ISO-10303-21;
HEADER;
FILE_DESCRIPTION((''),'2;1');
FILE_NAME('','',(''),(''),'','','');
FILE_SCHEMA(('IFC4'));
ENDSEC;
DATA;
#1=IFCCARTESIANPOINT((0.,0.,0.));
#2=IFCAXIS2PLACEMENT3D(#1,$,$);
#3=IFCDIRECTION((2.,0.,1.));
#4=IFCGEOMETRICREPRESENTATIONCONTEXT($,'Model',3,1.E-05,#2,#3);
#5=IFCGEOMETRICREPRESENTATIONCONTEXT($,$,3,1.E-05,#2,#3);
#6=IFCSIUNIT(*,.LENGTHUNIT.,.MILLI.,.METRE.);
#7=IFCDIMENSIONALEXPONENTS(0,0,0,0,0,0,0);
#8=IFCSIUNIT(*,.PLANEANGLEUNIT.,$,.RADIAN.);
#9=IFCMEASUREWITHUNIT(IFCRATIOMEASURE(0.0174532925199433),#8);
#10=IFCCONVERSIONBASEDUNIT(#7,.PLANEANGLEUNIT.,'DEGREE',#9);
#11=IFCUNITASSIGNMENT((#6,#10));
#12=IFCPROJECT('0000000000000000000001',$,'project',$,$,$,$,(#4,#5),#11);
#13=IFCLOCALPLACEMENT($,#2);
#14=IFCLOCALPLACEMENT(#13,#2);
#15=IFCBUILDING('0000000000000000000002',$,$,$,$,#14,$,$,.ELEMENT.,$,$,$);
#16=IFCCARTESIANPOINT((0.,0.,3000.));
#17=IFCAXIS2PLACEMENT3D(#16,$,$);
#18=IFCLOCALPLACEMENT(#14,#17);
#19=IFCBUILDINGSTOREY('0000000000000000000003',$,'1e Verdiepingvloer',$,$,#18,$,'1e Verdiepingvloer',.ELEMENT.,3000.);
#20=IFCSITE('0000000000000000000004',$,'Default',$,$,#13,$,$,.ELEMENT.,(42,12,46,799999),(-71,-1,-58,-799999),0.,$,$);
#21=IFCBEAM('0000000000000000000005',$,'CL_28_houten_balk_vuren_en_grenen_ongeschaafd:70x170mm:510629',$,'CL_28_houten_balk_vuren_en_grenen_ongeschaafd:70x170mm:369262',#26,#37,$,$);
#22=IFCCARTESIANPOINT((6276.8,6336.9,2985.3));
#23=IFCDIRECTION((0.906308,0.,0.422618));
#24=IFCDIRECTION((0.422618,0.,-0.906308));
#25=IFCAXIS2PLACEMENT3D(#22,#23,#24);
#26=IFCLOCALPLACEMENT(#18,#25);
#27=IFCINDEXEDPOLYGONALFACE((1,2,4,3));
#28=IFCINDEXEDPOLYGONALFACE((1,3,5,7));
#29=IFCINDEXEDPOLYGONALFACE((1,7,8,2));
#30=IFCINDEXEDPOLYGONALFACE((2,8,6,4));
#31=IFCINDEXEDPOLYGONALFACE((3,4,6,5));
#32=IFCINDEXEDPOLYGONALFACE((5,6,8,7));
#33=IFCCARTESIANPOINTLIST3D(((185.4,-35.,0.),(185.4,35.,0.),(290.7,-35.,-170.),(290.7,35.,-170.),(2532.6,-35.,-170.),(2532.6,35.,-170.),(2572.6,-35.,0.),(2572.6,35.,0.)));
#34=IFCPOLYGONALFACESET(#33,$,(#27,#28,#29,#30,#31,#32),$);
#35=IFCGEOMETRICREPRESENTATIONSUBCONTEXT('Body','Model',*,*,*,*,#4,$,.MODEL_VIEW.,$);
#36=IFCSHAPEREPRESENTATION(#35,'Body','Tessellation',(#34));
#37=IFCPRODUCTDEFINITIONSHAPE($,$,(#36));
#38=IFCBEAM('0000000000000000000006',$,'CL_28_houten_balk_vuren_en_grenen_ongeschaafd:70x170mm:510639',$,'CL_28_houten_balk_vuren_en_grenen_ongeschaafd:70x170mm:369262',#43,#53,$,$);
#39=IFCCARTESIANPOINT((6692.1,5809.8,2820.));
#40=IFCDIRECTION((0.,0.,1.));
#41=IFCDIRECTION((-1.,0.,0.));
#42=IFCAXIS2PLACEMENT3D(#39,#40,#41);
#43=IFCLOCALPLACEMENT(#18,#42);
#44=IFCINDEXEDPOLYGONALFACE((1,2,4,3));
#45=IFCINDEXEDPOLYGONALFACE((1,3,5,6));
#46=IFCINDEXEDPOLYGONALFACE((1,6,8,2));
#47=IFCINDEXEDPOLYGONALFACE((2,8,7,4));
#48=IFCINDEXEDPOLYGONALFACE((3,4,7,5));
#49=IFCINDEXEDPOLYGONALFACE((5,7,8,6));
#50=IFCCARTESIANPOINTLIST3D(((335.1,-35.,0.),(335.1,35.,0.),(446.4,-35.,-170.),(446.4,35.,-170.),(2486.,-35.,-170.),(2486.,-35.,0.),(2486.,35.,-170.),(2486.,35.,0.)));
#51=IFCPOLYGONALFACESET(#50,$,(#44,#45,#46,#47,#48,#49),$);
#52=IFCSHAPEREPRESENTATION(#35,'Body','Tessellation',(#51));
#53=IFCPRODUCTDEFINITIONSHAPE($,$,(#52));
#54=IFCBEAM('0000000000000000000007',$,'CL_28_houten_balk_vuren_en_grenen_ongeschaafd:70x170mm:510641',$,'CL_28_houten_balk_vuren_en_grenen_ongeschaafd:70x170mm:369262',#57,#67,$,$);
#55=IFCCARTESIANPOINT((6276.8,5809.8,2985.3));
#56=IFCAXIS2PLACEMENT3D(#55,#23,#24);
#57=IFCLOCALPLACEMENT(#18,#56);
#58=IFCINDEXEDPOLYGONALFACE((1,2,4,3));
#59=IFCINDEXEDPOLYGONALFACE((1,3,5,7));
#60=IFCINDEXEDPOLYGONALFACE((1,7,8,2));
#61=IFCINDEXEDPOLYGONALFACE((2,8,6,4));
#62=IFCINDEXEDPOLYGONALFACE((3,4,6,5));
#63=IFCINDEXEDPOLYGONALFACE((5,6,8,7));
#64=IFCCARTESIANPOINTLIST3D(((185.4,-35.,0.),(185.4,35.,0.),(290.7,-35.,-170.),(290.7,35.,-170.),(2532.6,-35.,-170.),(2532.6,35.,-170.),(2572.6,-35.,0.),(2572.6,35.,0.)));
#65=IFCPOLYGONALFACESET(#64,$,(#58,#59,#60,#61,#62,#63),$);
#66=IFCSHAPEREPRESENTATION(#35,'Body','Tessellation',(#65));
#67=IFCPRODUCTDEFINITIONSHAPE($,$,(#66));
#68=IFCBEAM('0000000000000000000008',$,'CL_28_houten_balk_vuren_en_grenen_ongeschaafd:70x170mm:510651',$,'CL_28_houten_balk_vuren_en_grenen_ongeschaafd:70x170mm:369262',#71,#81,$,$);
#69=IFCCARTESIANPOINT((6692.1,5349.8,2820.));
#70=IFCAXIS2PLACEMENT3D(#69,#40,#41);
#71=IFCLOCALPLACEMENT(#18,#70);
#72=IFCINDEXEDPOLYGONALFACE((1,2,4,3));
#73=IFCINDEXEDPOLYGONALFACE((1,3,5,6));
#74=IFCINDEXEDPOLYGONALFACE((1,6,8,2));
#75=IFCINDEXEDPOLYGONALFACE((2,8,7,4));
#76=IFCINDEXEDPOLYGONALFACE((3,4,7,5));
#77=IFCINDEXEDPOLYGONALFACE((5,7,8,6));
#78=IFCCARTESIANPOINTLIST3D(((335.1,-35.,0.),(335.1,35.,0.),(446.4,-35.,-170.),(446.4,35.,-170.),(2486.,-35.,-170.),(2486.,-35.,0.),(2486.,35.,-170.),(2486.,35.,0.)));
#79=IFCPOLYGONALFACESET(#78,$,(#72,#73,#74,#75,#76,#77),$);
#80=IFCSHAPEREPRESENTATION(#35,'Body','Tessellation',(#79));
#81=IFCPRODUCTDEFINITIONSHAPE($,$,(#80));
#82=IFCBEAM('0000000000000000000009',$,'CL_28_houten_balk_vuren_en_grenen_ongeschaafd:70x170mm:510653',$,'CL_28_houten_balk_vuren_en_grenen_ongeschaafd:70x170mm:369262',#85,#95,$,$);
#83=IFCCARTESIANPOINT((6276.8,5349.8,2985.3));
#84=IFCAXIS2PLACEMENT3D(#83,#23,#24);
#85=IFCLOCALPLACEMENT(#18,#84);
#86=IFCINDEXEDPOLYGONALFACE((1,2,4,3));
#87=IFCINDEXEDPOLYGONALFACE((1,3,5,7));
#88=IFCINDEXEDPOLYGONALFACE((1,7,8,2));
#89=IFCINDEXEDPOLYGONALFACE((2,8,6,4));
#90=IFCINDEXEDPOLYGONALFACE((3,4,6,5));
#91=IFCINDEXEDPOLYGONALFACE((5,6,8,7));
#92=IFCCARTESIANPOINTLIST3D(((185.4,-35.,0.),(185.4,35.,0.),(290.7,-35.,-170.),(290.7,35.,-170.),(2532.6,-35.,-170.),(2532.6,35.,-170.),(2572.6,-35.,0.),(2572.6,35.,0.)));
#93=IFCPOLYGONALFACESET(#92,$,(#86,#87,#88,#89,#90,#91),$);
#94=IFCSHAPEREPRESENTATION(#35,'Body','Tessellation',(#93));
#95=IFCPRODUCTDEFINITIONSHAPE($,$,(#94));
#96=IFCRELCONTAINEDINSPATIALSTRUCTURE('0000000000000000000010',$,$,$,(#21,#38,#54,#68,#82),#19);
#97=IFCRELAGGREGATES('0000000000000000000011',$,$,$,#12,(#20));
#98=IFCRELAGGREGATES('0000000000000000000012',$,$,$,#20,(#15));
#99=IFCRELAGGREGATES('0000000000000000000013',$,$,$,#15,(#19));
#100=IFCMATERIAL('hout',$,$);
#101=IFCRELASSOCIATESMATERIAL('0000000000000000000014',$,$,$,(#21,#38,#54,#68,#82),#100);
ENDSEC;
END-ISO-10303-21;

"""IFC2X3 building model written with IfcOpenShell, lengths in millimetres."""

from ifc_helpers import new_model, entity, si_unit, converted_unit, direction, frame, frame_2d, origin, place, context, subcontext, project, spatial, rectangle, extrude, clip, halfspace, material, element, save


model = new_model("IFC2X3")

# Units and contexts
model_context = context("Model", 3, precision=1e-05, world=origin(), true_north=direction((2.0, 0.0, 1.0)))
context_of_model = context(None, 3, precision=1e-05, world=origin(), true_north=direction((2.0, 0.0, 1.0)))
body_context = subcontext(model_context, "Body", "Model", "MODEL_VIEW")
ifc_project = project(units=[si_unit("LENGTHUNIT", "METRE", prefix="MILLI"), converted_unit("PLANEANGLEUNIT", "DEGREE", entity("IfcRatioMeasure", 0.0174532925199433), si_unit("PLANEANGLEUNIT", "RADIAN"), dimensions=[0, 0, 0, 0, 0, 0, 0])], contexts=[model_context, context_of_model])

# Site, building, storey
site_placement = place(None, origin())
site = spatial("IfcSite", under=ifc_project, at=site_placement, Name="Default", CompositionType="ELEMENT", RefLatitude=(42, 12, 46, 799999), RefLongitude=(-71, -1, -58, -799999), RefElevation=0.0)
building_placement = place(site_placement, origin())
building = spatial("IfcBuilding", under=site, at=building_placement, CompositionType="ELEMENT")
storey_placement = place(building_placement, frame((0.0, 0.0, 3000.0)))
storey = spatial("IfcBuildingStorey", under=building, at=storey_placement, Name="1e Verdiepingvloer", LongName="1e Verdiepingvloer", CompositionType="ELEMENT", Elevation=3000.0)

# Beams
ifc_material_1 = material(Name="hout")
beam_1_placement = place(storey_placement, frame((6276.8, 6336.9, 2985.3), z_axis=(0.906308, 0.0, 0.422618), x_axis=(0.422618, 0.0, -0.906308)))
element("IfcBeam", 1, at=beam_1_placement, inside=storey, material=ifc_material_1, Name="CL_28_houten_balk_vuren_en_grenen_ongeschaafd:70x170mm:510629", ObjectType="CL_28_houten_balk_vuren_en_grenen_ongeschaafd:70x170mm:369262", context=body_context, shape_type="Clipping", body=[
    clip(clip(extrude(rectangle(XDim=170.0, YDim=70.0, at=frame_2d((0.0, 0.0), x_axis=(1.0, 0.0))), frame((185.4, 0.0, -85.0), z_axis=(1.0, 0.0, 0.0), x_axis=(0.0, 0.0, -1.0)), (0.0, 0.0, 1.0), 2387.2), halfspace(frame((2532.6, 1452.2, -170.0), z_axis=(0.973348, 0.0, -0.229334), x_axis=(0.229334, 0.0, 0.973348)), False)), halfspace(frame((290.7, 1452.2, -170.0), z_axis=(-0.850088, 0.0, -0.52664), x_axis=(-0.52664, 0.0, 0.850088)), False)),
])
beam_2_placement = place(storey_placement, frame((6692.1, 5809.8, 2820.0), z_axis=(0.0, 0.0, 1.0), x_axis=(-1.0, 0.0, 0.0)))
element("IfcBeam", 2, at=beam_2_placement, inside=storey, material=ifc_material_1, Name="CL_28_houten_balk_vuren_en_grenen_ongeschaafd:70x170mm:510639", ObjectType="CL_28_houten_balk_vuren_en_grenen_ongeschaafd:70x170mm:369262", context=body_context, shape_type="Clipping", body=[
    clip(extrude(rectangle(XDim=170.0, YDim=70.0, at=frame_2d((0.0, 0.0), x_axis=(1.0, 0.0))), frame((335.1, 0.0, -85.0), z_axis=(1.0, 0.0, 0.0), x_axis=(0.0, 0.0, -1.0)), (0.0, 0.0, 1.0), 2150.9), halfspace(frame((446.4, -1979.3, -170.0), z_axis=(-0.836561, 0.0, -0.547874), x_axis=(-0.547874, 0.0, 0.836561)), False)),
])
beam_3_placement = place(storey_placement, frame((6276.8, 5809.8, 2985.3), z_axis=(0.906308, 0.0, 0.422618), x_axis=(0.422618, 0.0, -0.906308)))
element("IfcBeam", 3, at=beam_3_placement, inside=storey, material=ifc_material_1, Name="CL_28_houten_balk_vuren_en_grenen_ongeschaafd:70x170mm:510641", ObjectType="CL_28_houten_balk_vuren_en_grenen_ongeschaafd:70x170mm:369262", context=body_context, shape_type="Clipping", body=[
    clip(clip(extrude(rectangle(XDim=170.0, YDim=70.0, at=frame_2d((0.0, 0.0), x_axis=(1.0, 0.0))), frame((185.4, 0.0, -85.0), z_axis=(1.0, 0.0, 0.0), x_axis=(0.0, 0.0, -1.0)), (0.0, 0.0, 1.0), 2387.2), halfspace(frame((2532.6, 1979.3, -170.0), z_axis=(0.973348, 0.0, -0.229334), x_axis=(0.229334, 0.0, 0.973348)), False)), halfspace(frame((290.7, 1979.3, -170.0), z_axis=(-0.850088, 0.0, -0.52664), x_axis=(-0.52664, 0.0, 0.850088)), False)),
])
beam_4_placement = place(storey_placement, frame((6692.1, 5349.8, 2820.0), z_axis=(0.0, 0.0, 1.0), x_axis=(-1.0, 0.0, 0.0)))
element("IfcBeam", 4, at=beam_4_placement, inside=storey, material=ifc_material_1, Name="CL_28_houten_balk_vuren_en_grenen_ongeschaafd:70x170mm:510651", ObjectType="CL_28_houten_balk_vuren_en_grenen_ongeschaafd:70x170mm:369262", context=body_context, shape_type="Clipping", body=[
    clip(extrude(rectangle(XDim=170.0, YDim=70.0, at=frame_2d((0.0, 0.0), x_axis=(1.0, 0.0))), frame((335.1, 0.0, -85.0), z_axis=(1.0, 0.0, 0.0), x_axis=(0.0, 0.0, -1.0)), (0.0, 0.0, 1.0), 2150.9), halfspace(frame((446.4, -2439.3, -170.0), z_axis=(-0.836561, 0.0, -0.547874), x_axis=(-0.547874, 0.0, 0.836561)), False)),
])
beam_5_placement = place(storey_placement, frame((6276.8, 5349.8, 2985.3), z_axis=(0.906308, 0.0, 0.422618), x_axis=(0.422618, 0.0, -0.906308)))
element("IfcBeam", 5, at=beam_5_placement, inside=storey, material=ifc_material_1, Name="CL_28_houten_balk_vuren_en_grenen_ongeschaafd:70x170mm:510653", ObjectType="CL_28_houten_balk_vuren_en_grenen_ongeschaafd:70x170mm:369262", context=body_context, shape_type="Clipping", body=[
    clip(clip(extrude(rectangle(XDim=170.0, YDim=70.0, at=frame_2d((0.0, 0.0), x_axis=(1.0, 0.0))), frame((185.4, 0.0, -85.0), z_axis=(1.0, 0.0, 0.0), x_axis=(0.0, 0.0, -1.0)), (0.0, 0.0, 1.0), 2387.2), halfspace(frame((2532.6, 2439.3, -170.0), z_axis=(0.973348, 0.0, -0.229334), x_axis=(0.229334, 0.0, 0.973348)), False)), halfspace(frame((290.7, 2439.3, -170.0), z_axis=(-0.850088, 0.0, -0.52664), x_axis=(-0.52664, 0.0, 0.850088)), False)),
])

save(model, "model.ifc")
